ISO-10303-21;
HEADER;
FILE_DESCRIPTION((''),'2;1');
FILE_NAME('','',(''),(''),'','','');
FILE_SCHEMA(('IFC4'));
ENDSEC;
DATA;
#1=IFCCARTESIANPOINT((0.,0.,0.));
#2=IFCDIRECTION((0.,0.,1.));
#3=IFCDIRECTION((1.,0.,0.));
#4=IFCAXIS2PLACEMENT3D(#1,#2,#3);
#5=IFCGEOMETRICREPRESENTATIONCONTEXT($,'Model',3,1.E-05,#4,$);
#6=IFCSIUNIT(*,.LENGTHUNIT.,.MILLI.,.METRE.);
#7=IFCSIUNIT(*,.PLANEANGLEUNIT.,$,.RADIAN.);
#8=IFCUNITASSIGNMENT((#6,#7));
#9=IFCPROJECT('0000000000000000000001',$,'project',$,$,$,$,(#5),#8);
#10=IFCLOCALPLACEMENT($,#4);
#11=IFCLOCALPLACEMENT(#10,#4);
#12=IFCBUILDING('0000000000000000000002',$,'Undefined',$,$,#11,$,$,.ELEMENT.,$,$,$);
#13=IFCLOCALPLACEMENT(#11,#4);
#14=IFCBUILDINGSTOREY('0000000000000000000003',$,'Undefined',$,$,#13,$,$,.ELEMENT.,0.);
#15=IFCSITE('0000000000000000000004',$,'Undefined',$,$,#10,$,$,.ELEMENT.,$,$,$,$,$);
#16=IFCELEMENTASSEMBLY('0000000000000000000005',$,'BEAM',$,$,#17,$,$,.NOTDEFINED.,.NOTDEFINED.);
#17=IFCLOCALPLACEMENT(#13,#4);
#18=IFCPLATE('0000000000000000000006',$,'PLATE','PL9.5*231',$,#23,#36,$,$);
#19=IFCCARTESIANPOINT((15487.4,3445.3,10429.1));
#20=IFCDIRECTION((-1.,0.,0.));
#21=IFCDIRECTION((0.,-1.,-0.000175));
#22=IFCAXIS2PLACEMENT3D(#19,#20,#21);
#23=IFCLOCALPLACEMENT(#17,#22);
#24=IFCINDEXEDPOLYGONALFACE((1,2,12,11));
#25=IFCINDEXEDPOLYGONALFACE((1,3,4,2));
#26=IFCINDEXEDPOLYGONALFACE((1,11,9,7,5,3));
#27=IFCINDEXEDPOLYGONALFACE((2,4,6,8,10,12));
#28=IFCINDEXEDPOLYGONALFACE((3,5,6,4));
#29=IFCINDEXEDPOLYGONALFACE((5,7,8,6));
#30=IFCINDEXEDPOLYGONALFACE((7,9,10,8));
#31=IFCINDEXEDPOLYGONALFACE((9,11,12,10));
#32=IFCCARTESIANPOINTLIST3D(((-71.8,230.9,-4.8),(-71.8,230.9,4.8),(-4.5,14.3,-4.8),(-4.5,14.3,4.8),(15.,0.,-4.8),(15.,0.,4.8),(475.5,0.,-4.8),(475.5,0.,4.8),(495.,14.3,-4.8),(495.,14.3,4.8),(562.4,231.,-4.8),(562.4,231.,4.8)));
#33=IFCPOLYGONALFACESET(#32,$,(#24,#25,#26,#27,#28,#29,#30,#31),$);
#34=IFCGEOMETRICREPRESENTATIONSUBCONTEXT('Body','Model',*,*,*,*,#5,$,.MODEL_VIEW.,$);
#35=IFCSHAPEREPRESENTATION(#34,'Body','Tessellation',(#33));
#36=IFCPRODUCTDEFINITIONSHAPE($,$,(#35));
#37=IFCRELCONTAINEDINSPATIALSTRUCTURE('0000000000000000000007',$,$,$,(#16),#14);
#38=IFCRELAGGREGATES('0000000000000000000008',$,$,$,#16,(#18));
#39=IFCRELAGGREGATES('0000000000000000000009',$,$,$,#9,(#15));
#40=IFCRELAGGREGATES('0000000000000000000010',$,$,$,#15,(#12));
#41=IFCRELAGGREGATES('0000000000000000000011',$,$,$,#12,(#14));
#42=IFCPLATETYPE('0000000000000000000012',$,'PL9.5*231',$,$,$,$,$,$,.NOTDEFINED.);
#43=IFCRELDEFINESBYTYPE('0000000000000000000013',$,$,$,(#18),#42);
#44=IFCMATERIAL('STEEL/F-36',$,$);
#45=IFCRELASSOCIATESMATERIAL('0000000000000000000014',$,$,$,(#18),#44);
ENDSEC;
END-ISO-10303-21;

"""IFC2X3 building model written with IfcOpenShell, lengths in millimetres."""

from ifc_helpers import new_model, si_unit, frame, origin_with_axes, place, context, subcontext, project, spatial, polyline, outline, extrude, material, type_object, element, aggregate, save


model = new_model("IFC2X3")

# Units and contexts
model_context = context("Model", 3, precision=1e-05, world=origin_with_axes())
body_context = subcontext(model_context, "Body", "Model", "MODEL_VIEW")
ifc_project = project(units=[si_unit("LENGTHUNIT", "METRE", prefix="MILLI"), si_unit("PLANEANGLEUNIT", "RADIAN")], contexts=[model_context])

# Site, building, storey
site_placement = place(None, origin_with_axes())
site = spatial("IfcSite", under=ifc_project, at=site_placement, Name="Undefined", CompositionType="ELEMENT")
building_placement = place(site_placement, origin_with_axes())
building = spatial("IfcBuilding", under=site, at=building_placement, Name="Undefined", CompositionType="ELEMENT")
storey_placement = place(building_placement, origin_with_axes())
storey = spatial("IfcBuildingStorey", under=building, at=storey_placement, Name="Undefined", CompositionType="ELEMENT", Elevation=0.0)

# Shared definitions
ifc_material_1 = material(Name="STEEL/F-36")

# Element assembly
assembly_1_placement = place(storey_placement, origin_with_axes())
assembly_1 = element("IfcElementAssembly", 1, at=assembly_1_placement, inside=storey, Name="BEAM", AssemblyPlace="NOTDEFINED", PredefinedType="NOTDEFINED")

# Plate
plate_type_1 = type_object("IfcPlateType", Name="PL9.5*231", PredefinedType="NOTDEFINED")
plate_1_placement = place(assembly_1_placement, frame((15487.4, 3445.3, 10429.1), z_axis=(-1.0, 0.0, 0.0), x_axis=(0.0, -1.0, -0.000175)))
plate_1 = element("IfcPlate", 2, at=plate_1_placement, type_object=plate_type_1, material=ifc_material_1, Name="PLATE", Description="PL9.5*231", context=body_context, shape_type="SweptSolid", body=[
    extrude(outline(polyline([(-4.5, 14.3), (15.0, 0.0), (475.5, 0.0), (495.0, 14.3), (562.4, 231.0), (-71.8, 230.9), (-4.5, 14.3)])), frame((0.0, 0.0, -4.8), z_axis=(0.0, 0.0, 1.0), x_axis=(1.0, 0.0, 0.0)), (0.0, 0.0, 1.0), 9.5),
])

aggregate(assembly_1, [plate_1])

save(model, "model.ifc")
